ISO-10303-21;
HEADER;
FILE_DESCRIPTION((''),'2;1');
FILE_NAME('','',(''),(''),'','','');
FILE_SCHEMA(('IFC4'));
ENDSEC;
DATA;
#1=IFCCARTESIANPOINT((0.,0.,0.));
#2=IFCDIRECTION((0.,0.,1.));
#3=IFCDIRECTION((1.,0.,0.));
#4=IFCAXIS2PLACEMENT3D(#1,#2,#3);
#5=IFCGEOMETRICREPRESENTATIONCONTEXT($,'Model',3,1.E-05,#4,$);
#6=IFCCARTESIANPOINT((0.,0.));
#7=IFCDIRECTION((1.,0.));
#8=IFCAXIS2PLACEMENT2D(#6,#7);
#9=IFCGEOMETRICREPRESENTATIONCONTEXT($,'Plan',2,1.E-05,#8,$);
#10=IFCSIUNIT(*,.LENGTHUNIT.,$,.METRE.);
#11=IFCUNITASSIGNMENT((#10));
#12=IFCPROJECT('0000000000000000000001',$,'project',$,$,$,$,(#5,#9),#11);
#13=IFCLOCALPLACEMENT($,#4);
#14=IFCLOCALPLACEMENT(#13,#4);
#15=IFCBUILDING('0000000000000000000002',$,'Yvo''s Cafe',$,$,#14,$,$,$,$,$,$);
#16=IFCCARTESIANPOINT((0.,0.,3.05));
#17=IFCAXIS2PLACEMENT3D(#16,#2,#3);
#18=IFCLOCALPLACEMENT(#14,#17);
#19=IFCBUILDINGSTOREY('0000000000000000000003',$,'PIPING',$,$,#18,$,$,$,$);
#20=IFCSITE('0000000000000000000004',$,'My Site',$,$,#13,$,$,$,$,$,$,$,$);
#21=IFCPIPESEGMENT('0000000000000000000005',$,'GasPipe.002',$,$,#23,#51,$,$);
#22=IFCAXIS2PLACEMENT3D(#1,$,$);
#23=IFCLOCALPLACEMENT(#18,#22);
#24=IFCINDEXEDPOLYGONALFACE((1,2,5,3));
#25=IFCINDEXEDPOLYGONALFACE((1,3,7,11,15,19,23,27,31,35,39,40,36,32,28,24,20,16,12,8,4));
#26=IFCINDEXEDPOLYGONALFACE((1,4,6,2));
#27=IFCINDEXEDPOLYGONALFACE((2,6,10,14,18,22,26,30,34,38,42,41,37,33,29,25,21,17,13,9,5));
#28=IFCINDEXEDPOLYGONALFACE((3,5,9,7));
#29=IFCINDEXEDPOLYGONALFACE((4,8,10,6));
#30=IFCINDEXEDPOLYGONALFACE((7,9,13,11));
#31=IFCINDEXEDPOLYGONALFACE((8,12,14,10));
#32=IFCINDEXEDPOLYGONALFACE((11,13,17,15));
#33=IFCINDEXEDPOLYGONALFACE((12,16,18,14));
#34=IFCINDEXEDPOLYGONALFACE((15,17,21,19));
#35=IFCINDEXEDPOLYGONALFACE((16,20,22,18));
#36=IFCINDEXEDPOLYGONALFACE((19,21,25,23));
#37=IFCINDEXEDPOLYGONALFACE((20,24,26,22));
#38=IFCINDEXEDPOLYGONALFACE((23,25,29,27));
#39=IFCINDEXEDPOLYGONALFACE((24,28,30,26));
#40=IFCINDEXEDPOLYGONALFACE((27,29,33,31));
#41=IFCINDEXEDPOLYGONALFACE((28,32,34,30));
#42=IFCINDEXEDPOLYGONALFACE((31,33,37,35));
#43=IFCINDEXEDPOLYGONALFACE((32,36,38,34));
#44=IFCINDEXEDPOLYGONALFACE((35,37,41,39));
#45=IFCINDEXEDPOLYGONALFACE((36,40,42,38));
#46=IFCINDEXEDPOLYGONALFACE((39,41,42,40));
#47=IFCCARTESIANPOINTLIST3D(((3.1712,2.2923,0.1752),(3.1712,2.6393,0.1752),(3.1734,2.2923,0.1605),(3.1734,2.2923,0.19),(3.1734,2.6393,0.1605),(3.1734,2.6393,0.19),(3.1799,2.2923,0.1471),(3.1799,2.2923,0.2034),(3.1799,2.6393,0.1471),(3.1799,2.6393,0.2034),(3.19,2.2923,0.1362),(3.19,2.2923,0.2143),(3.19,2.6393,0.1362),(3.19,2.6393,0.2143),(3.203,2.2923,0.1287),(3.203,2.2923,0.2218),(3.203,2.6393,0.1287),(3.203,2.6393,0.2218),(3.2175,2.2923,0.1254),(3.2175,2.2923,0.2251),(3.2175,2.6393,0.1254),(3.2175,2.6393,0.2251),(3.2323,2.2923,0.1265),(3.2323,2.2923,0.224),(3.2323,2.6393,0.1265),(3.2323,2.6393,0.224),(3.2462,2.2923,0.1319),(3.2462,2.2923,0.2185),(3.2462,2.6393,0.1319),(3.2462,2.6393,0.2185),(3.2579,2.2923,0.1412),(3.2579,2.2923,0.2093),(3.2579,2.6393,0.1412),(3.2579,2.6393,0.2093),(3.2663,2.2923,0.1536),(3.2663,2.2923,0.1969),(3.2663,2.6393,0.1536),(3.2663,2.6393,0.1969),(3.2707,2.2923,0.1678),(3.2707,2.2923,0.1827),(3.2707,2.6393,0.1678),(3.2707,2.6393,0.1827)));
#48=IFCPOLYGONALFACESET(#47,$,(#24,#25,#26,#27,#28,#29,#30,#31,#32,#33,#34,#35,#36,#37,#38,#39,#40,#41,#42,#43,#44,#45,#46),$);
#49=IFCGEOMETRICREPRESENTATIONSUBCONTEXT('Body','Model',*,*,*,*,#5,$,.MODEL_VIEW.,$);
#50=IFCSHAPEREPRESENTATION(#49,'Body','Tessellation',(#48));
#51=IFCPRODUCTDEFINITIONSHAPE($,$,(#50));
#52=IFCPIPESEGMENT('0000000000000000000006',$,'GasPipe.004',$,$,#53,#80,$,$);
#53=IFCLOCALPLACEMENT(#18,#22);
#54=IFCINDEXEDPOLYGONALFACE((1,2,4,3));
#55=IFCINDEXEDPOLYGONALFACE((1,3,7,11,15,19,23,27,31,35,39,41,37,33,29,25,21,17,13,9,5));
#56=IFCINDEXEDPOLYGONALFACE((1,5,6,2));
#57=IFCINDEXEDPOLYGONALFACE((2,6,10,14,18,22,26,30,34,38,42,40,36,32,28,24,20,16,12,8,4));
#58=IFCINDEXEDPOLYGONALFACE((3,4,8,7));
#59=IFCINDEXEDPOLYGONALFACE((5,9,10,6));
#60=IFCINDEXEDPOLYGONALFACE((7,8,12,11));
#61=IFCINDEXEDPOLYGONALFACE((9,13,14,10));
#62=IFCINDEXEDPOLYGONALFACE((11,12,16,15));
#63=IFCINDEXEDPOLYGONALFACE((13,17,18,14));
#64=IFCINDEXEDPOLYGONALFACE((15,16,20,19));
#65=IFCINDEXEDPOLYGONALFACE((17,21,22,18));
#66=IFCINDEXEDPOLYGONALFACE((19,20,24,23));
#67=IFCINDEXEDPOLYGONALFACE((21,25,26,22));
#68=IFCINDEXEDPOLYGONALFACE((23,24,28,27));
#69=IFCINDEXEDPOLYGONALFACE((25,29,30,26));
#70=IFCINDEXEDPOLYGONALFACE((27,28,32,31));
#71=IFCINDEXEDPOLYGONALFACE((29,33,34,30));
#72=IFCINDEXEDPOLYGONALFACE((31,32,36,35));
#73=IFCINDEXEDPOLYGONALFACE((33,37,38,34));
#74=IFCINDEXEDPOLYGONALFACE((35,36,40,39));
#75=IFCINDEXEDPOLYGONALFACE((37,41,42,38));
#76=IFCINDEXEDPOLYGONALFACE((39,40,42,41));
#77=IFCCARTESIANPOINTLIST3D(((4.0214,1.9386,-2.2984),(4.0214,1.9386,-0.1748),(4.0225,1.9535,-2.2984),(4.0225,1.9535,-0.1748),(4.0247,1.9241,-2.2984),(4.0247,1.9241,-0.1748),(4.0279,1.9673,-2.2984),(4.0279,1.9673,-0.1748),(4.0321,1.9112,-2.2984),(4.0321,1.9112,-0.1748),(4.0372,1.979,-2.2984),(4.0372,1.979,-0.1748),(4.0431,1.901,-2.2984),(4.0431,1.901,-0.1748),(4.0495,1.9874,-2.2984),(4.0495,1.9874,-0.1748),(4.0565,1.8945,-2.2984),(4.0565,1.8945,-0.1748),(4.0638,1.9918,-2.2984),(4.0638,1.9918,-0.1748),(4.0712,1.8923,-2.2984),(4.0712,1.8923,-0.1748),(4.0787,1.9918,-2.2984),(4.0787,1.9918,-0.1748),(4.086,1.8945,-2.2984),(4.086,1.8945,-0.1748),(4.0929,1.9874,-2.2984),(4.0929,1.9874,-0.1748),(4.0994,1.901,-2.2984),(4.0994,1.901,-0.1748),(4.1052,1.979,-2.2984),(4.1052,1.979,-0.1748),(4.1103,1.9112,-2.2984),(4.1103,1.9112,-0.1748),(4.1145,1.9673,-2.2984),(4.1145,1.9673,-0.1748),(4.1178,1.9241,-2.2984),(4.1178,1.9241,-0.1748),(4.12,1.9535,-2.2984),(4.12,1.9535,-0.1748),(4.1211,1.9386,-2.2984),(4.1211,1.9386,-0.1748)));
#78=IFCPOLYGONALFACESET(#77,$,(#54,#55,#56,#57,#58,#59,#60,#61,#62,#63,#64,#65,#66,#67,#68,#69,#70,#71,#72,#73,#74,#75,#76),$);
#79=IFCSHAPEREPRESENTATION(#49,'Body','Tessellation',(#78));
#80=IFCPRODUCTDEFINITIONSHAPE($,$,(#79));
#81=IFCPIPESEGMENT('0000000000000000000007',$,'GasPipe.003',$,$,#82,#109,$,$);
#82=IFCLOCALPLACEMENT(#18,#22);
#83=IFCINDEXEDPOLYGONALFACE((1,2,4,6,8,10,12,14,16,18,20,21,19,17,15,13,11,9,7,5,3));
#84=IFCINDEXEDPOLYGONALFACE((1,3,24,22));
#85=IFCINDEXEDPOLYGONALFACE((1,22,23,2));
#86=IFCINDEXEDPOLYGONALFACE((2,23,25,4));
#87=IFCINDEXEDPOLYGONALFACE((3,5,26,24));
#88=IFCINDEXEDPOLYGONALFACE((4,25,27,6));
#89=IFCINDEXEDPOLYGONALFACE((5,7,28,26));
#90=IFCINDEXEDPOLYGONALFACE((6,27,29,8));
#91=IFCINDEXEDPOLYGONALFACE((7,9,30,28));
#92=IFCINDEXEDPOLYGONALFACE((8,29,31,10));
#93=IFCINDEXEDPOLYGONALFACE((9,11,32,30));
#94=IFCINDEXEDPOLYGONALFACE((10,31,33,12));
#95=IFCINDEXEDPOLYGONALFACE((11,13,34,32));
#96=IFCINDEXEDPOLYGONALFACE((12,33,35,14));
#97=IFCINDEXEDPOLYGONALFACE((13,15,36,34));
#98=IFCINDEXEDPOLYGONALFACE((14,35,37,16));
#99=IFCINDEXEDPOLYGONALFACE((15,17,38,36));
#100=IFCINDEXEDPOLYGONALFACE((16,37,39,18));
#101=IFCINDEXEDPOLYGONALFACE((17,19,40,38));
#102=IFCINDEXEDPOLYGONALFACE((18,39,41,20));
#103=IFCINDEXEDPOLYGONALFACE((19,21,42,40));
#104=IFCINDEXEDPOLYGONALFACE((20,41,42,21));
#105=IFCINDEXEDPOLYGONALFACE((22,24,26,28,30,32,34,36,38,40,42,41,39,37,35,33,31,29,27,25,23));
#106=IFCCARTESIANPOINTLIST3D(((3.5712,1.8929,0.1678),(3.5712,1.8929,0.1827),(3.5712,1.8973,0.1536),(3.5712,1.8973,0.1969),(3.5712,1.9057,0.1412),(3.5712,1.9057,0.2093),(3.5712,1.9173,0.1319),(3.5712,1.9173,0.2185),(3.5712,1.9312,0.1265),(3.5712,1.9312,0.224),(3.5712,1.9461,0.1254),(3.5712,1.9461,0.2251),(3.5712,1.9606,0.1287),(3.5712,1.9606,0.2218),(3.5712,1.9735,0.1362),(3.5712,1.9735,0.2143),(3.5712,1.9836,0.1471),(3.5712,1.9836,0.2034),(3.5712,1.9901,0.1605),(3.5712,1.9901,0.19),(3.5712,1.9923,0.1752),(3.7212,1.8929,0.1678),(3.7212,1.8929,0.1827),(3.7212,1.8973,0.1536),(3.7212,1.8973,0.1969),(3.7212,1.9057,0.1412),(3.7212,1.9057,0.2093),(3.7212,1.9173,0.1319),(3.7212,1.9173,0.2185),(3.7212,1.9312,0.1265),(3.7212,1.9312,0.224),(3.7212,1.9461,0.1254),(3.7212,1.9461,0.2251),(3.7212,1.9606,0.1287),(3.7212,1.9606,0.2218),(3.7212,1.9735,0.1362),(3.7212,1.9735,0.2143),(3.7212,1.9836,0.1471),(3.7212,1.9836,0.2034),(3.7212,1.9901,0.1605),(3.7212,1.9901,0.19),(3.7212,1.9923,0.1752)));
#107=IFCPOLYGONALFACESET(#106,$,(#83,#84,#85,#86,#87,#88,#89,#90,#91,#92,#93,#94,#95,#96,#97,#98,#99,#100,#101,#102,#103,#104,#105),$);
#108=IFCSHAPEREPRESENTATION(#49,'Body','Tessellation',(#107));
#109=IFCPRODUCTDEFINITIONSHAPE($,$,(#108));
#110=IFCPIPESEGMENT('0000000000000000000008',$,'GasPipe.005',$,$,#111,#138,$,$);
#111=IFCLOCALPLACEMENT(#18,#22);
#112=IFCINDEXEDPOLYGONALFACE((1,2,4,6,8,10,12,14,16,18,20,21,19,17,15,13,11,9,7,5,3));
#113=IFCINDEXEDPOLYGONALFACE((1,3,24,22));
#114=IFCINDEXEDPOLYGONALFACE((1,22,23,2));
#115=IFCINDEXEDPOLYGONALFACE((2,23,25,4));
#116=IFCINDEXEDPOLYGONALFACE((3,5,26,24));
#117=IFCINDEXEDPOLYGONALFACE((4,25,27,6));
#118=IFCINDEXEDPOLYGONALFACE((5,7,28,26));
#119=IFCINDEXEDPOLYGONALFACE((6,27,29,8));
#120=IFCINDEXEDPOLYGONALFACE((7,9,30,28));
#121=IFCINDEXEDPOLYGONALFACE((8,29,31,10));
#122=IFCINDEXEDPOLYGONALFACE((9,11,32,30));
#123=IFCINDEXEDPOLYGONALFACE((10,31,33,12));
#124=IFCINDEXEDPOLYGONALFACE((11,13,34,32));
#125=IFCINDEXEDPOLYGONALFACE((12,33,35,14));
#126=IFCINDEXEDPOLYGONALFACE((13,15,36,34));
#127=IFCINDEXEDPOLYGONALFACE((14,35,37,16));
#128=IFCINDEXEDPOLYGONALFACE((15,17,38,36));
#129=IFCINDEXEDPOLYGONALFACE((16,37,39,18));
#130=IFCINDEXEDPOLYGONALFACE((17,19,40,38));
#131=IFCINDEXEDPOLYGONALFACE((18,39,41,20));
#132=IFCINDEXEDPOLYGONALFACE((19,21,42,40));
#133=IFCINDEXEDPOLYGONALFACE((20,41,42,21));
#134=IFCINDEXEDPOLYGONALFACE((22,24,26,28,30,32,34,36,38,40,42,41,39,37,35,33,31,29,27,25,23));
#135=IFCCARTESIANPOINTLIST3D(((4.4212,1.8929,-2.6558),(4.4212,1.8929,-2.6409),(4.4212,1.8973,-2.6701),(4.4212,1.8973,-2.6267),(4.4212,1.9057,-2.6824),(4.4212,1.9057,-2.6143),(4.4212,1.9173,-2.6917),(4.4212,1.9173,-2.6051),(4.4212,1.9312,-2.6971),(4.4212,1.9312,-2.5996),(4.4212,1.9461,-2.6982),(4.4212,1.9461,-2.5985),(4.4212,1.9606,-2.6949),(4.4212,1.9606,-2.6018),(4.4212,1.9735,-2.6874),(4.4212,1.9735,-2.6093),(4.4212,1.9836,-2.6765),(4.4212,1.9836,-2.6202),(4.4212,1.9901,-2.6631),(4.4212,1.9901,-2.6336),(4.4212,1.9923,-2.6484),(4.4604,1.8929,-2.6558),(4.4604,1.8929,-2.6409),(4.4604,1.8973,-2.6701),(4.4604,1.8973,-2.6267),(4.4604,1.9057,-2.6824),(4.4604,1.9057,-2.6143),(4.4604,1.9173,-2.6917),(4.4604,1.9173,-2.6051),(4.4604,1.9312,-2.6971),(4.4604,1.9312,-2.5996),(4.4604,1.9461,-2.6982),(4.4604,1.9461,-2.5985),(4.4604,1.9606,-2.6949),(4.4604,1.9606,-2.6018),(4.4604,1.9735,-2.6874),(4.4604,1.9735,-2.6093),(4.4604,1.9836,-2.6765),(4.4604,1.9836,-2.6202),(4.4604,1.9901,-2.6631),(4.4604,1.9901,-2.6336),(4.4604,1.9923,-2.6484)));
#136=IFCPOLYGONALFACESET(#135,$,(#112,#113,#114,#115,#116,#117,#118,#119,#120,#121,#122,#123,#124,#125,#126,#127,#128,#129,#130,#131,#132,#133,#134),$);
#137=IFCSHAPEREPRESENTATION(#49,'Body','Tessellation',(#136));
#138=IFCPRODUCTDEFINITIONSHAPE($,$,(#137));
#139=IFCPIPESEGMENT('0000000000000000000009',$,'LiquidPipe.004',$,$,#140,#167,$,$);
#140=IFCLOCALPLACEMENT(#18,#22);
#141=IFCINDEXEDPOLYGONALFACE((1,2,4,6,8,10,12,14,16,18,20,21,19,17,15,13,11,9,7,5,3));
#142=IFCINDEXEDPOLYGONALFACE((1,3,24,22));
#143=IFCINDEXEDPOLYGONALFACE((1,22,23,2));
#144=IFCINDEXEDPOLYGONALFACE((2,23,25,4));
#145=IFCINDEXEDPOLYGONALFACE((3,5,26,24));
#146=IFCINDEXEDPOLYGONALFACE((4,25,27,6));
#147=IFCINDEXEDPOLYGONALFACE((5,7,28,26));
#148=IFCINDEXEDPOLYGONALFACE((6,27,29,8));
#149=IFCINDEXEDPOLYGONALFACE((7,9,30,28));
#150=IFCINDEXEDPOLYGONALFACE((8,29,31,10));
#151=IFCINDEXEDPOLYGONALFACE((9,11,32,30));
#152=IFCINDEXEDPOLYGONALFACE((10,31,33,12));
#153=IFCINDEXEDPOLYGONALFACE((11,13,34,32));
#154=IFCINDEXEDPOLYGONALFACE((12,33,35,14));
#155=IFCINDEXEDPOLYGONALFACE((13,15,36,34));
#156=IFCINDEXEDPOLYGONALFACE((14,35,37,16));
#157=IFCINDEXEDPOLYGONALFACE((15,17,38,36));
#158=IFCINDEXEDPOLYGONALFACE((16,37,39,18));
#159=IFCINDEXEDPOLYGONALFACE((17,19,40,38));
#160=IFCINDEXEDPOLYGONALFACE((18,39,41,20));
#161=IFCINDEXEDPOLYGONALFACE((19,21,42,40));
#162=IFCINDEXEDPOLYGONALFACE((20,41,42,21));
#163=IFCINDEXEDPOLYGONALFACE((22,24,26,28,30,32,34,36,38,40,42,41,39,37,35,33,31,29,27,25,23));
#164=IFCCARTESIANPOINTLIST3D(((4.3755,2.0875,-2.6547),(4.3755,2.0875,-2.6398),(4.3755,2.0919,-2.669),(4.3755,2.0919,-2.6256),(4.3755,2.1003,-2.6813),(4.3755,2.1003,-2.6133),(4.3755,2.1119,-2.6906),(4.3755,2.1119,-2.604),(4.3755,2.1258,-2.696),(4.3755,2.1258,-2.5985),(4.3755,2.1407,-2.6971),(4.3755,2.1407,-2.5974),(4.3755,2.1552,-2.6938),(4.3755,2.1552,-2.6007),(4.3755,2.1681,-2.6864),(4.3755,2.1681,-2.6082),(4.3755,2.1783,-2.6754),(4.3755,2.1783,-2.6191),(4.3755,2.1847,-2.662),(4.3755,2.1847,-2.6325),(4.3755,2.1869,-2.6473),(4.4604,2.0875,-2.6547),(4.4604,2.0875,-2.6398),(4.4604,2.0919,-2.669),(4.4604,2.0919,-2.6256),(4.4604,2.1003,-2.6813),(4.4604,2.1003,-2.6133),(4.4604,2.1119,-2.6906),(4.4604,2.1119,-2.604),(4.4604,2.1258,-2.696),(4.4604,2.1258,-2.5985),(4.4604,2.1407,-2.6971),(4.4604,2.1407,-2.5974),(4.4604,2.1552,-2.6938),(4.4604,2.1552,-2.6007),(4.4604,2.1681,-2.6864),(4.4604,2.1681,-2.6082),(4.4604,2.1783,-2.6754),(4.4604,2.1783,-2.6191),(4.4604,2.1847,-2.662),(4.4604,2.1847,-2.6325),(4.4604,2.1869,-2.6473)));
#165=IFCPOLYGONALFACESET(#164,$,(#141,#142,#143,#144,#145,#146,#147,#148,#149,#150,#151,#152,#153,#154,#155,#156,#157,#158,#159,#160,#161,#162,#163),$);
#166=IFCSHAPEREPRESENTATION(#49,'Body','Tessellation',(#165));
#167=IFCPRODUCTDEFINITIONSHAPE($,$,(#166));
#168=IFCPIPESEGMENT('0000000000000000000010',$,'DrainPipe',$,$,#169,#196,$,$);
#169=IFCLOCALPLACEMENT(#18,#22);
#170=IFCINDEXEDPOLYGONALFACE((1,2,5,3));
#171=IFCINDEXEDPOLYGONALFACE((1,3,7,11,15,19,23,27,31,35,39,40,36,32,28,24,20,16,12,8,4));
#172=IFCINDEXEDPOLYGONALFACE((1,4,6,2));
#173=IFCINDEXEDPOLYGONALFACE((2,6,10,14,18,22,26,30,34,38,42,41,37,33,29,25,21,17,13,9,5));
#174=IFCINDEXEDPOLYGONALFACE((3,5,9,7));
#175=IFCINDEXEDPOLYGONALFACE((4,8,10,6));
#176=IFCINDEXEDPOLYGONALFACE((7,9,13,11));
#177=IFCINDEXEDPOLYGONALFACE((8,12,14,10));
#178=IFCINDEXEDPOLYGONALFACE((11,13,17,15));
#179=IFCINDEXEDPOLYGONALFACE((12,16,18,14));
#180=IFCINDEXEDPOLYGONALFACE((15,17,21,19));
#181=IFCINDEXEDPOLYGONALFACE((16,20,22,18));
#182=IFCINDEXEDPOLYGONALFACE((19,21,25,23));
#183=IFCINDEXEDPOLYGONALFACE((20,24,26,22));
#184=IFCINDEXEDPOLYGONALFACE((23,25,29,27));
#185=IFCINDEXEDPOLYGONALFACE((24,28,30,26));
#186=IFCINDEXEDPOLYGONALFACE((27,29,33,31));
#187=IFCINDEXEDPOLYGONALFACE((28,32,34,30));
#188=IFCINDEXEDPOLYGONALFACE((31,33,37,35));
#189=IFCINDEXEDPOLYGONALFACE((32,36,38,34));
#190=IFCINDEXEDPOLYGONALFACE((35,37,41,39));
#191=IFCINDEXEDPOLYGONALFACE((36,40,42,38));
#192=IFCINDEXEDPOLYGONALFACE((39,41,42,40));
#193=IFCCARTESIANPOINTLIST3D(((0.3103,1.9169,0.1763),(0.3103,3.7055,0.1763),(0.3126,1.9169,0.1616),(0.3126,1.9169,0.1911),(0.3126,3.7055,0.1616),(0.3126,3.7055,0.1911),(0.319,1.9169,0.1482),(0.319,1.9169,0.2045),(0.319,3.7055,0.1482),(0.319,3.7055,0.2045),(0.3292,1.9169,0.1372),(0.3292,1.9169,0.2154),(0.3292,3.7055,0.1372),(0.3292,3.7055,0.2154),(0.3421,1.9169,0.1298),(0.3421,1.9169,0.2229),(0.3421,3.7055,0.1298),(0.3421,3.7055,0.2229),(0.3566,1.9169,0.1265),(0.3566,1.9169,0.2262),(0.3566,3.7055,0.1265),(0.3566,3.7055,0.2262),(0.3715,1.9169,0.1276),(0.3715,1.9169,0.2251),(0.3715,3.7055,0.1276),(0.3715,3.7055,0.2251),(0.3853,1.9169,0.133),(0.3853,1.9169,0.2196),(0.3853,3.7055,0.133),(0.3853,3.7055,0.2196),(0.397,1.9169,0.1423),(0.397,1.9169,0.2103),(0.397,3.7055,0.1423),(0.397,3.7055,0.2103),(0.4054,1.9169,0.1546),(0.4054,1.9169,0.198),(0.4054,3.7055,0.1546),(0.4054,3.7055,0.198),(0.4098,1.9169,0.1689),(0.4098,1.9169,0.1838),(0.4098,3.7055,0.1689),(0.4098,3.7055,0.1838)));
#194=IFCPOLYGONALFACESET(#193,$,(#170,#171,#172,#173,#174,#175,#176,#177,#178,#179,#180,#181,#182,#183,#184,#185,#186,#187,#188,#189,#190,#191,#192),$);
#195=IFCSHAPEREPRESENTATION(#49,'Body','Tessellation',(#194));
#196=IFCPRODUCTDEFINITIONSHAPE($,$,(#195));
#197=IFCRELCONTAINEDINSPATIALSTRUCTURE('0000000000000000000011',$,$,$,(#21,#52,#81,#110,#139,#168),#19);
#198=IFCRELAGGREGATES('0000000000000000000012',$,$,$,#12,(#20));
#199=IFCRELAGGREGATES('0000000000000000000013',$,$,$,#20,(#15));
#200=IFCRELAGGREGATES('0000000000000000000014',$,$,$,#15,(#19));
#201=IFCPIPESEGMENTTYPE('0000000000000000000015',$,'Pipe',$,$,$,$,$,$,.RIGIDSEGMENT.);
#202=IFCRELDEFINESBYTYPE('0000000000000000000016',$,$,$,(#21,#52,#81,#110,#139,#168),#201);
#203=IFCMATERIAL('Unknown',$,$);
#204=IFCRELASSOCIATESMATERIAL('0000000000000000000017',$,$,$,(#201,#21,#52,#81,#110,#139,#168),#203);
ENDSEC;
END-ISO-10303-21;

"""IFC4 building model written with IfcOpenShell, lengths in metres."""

from ifc_helpers import new_model, si_unit, frame, origin_with_axes, origin_2d_with_axis, place, context, subcontext, project, spatial, circle, extrude, material, material_profile, profile_set, profile_usage, type_object, element, save


model = new_model("IFC4")

# Units and contexts
model_context = context("Model", 3, precision=1e-05, world=origin_with_axes())
plan_context = context("Plan", 2, precision=1e-05, world=origin_2d_with_axis())
body_context = subcontext(model_context, "Body", "Model", "MODEL_VIEW")
ifc_project = project(units=[si_unit("LENGTHUNIT", "METRE")], contexts=[model_context, plan_context])

# Site, building, storey
site_placement = place(None, origin_with_axes())
site = spatial("IfcSite", under=ifc_project, at=site_placement, Name="My Site")
building_placement = place(site_placement, origin_with_axes())
building = spatial("IfcBuilding", under=site, at=building_placement, Name="Yvo's Cafe")
storey_placement = place(building_placement, frame((0.0, 0.0, 3.05), z_axis=(0.0, 0.0, 1.0), x_axis=(1.0, 0.0, 0.0)))
storey = spatial("IfcBuildingStorey", under=building, at=storey_placement, Name="PIPING")

# Pipe segments
ifc_material = material(Name="Unknown")
ifc_material_profile = material_profile(ifc_material, circle(Radius=0.05))
ifc_profile_set = profile_set([ifc_material_profile])
pipe_segment_type = type_object("IfcPipeSegmentType", Name="Pipe", PredefinedType="RIGIDSEGMENT", material=ifc_profile_set)
ifc_profile_usage_1 = profile_usage(ifc_profile_set, cardinal=5)
pipe_segment_1_placement = place(storey_placement, frame((3.2212, 2.2923, 0.1752), z_axis=(0.0, 1.0, 0.0), x_axis=(-1.0, 0.0, 0.0)))
element("IfcPipeSegment", 1, at=pipe_segment_1_placement, inside=storey, type_object=pipe_segment_type, material=ifc_profile_usage_1, Name="GasPipe.002", context=body_context, shape_type="SweptSolid", body=[
    extrude(circle(Radius=0.05), origin_with_axes(), (0.0, 0.0, 1.0), 0.3469),
])
ifc_profile_usage_2 = profile_usage(ifc_profile_set, cardinal=5)
pipe_segment_2_placement = place(storey_placement, frame((4.0712, 1.9423, -2.2984), z_axis=(0.0, 0.0, 1.0), x_axis=(0.0, -1.0, 0.0)))
element("IfcPipeSegment", 2, at=pipe_segment_2_placement, inside=storey, type_object=pipe_segment_type, material=ifc_profile_usage_2, Name="GasPipe.004", context=body_context, shape_type="SweptSolid", body=[
    extrude(circle(Radius=0.05), origin_with_axes(), (0.0, 0.0, 1.0), 2.1236),
])
ifc_profile_usage_3 = profile_usage(ifc_profile_set, cardinal=5)
pipe_segment_3_placement = place(storey_placement, frame((3.5712, 1.9423, 0.1752), z_axis=(1.0, 0.0, 0.0), x_axis=(0.0, 1.0, 0.0)))
element("IfcPipeSegment", 3, at=pipe_segment_3_placement, inside=storey, type_object=pipe_segment_type, material=ifc_profile_usage_3, Name="GasPipe.003", context=body_context, shape_type="SweptSolid", body=[
    extrude(circle(Radius=0.05), origin_with_axes(), (0.0, 0.0, 1.0), 0.15),
])
ifc_profile_usage_4 = profile_usage(ifc_profile_set, cardinal=5)
pipe_segment_4_placement = place(storey_placement, frame((4.4212, 1.9423, -2.6484), z_axis=(1.0, 0.0, 0.0), x_axis=(0.0, 1.0, 0.0)))
element("IfcPipeSegment", 4, at=pipe_segment_4_placement, inside=storey, type_object=pipe_segment_type, material=ifc_profile_usage_4, Name="GasPipe.005", context=body_context, shape_type="SweptSolid", body=[
    extrude(circle(Radius=0.05), origin_with_axes(), (0.0, 0.0, 1.0), 0.0392),
])
ifc_profile_usage_5 = profile_usage(ifc_profile_set, cardinal=5)
pipe_segment_5_placement = place(storey_placement, frame((4.3755, 2.1369, -2.6473), z_axis=(1.0, 0.0, 0.0), x_axis=(0.0, 1.0, 0.0)))
element("IfcPipeSegment", 5, at=pipe_segment_5_placement, inside=storey, type_object=pipe_segment_type, material=ifc_profile_usage_5, Name="LiquidPipe.004", context=body_context, shape_type="SweptSolid", body=[
    extrude(circle(Radius=0.05), origin_with_axes(), (0.0, 0.0, 1.0), 0.0849),
])
ifc_profile_usage_6 = profile_usage(ifc_profile_set, cardinal=5)
pipe_segment_6_placement = place(storey_placement, frame((0.3603, 1.9169, 0.1763), z_axis=(0.0, 1.0, 0.0), x_axis=(-1.0, 0.0, 0.0)))
element("IfcPipeSegment", 6, at=pipe_segment_6_placement, inside=storey, type_object=pipe_segment_type, material=ifc_profile_usage_6, Name="DrainPipe", context=body_context, shape_type="SweptSolid", body=[
    extrude(circle(Radius=0.05), origin_with_axes(), (0.0, 0.0, 1.0), 1.7886),
])

save(model, "model.ifc")
